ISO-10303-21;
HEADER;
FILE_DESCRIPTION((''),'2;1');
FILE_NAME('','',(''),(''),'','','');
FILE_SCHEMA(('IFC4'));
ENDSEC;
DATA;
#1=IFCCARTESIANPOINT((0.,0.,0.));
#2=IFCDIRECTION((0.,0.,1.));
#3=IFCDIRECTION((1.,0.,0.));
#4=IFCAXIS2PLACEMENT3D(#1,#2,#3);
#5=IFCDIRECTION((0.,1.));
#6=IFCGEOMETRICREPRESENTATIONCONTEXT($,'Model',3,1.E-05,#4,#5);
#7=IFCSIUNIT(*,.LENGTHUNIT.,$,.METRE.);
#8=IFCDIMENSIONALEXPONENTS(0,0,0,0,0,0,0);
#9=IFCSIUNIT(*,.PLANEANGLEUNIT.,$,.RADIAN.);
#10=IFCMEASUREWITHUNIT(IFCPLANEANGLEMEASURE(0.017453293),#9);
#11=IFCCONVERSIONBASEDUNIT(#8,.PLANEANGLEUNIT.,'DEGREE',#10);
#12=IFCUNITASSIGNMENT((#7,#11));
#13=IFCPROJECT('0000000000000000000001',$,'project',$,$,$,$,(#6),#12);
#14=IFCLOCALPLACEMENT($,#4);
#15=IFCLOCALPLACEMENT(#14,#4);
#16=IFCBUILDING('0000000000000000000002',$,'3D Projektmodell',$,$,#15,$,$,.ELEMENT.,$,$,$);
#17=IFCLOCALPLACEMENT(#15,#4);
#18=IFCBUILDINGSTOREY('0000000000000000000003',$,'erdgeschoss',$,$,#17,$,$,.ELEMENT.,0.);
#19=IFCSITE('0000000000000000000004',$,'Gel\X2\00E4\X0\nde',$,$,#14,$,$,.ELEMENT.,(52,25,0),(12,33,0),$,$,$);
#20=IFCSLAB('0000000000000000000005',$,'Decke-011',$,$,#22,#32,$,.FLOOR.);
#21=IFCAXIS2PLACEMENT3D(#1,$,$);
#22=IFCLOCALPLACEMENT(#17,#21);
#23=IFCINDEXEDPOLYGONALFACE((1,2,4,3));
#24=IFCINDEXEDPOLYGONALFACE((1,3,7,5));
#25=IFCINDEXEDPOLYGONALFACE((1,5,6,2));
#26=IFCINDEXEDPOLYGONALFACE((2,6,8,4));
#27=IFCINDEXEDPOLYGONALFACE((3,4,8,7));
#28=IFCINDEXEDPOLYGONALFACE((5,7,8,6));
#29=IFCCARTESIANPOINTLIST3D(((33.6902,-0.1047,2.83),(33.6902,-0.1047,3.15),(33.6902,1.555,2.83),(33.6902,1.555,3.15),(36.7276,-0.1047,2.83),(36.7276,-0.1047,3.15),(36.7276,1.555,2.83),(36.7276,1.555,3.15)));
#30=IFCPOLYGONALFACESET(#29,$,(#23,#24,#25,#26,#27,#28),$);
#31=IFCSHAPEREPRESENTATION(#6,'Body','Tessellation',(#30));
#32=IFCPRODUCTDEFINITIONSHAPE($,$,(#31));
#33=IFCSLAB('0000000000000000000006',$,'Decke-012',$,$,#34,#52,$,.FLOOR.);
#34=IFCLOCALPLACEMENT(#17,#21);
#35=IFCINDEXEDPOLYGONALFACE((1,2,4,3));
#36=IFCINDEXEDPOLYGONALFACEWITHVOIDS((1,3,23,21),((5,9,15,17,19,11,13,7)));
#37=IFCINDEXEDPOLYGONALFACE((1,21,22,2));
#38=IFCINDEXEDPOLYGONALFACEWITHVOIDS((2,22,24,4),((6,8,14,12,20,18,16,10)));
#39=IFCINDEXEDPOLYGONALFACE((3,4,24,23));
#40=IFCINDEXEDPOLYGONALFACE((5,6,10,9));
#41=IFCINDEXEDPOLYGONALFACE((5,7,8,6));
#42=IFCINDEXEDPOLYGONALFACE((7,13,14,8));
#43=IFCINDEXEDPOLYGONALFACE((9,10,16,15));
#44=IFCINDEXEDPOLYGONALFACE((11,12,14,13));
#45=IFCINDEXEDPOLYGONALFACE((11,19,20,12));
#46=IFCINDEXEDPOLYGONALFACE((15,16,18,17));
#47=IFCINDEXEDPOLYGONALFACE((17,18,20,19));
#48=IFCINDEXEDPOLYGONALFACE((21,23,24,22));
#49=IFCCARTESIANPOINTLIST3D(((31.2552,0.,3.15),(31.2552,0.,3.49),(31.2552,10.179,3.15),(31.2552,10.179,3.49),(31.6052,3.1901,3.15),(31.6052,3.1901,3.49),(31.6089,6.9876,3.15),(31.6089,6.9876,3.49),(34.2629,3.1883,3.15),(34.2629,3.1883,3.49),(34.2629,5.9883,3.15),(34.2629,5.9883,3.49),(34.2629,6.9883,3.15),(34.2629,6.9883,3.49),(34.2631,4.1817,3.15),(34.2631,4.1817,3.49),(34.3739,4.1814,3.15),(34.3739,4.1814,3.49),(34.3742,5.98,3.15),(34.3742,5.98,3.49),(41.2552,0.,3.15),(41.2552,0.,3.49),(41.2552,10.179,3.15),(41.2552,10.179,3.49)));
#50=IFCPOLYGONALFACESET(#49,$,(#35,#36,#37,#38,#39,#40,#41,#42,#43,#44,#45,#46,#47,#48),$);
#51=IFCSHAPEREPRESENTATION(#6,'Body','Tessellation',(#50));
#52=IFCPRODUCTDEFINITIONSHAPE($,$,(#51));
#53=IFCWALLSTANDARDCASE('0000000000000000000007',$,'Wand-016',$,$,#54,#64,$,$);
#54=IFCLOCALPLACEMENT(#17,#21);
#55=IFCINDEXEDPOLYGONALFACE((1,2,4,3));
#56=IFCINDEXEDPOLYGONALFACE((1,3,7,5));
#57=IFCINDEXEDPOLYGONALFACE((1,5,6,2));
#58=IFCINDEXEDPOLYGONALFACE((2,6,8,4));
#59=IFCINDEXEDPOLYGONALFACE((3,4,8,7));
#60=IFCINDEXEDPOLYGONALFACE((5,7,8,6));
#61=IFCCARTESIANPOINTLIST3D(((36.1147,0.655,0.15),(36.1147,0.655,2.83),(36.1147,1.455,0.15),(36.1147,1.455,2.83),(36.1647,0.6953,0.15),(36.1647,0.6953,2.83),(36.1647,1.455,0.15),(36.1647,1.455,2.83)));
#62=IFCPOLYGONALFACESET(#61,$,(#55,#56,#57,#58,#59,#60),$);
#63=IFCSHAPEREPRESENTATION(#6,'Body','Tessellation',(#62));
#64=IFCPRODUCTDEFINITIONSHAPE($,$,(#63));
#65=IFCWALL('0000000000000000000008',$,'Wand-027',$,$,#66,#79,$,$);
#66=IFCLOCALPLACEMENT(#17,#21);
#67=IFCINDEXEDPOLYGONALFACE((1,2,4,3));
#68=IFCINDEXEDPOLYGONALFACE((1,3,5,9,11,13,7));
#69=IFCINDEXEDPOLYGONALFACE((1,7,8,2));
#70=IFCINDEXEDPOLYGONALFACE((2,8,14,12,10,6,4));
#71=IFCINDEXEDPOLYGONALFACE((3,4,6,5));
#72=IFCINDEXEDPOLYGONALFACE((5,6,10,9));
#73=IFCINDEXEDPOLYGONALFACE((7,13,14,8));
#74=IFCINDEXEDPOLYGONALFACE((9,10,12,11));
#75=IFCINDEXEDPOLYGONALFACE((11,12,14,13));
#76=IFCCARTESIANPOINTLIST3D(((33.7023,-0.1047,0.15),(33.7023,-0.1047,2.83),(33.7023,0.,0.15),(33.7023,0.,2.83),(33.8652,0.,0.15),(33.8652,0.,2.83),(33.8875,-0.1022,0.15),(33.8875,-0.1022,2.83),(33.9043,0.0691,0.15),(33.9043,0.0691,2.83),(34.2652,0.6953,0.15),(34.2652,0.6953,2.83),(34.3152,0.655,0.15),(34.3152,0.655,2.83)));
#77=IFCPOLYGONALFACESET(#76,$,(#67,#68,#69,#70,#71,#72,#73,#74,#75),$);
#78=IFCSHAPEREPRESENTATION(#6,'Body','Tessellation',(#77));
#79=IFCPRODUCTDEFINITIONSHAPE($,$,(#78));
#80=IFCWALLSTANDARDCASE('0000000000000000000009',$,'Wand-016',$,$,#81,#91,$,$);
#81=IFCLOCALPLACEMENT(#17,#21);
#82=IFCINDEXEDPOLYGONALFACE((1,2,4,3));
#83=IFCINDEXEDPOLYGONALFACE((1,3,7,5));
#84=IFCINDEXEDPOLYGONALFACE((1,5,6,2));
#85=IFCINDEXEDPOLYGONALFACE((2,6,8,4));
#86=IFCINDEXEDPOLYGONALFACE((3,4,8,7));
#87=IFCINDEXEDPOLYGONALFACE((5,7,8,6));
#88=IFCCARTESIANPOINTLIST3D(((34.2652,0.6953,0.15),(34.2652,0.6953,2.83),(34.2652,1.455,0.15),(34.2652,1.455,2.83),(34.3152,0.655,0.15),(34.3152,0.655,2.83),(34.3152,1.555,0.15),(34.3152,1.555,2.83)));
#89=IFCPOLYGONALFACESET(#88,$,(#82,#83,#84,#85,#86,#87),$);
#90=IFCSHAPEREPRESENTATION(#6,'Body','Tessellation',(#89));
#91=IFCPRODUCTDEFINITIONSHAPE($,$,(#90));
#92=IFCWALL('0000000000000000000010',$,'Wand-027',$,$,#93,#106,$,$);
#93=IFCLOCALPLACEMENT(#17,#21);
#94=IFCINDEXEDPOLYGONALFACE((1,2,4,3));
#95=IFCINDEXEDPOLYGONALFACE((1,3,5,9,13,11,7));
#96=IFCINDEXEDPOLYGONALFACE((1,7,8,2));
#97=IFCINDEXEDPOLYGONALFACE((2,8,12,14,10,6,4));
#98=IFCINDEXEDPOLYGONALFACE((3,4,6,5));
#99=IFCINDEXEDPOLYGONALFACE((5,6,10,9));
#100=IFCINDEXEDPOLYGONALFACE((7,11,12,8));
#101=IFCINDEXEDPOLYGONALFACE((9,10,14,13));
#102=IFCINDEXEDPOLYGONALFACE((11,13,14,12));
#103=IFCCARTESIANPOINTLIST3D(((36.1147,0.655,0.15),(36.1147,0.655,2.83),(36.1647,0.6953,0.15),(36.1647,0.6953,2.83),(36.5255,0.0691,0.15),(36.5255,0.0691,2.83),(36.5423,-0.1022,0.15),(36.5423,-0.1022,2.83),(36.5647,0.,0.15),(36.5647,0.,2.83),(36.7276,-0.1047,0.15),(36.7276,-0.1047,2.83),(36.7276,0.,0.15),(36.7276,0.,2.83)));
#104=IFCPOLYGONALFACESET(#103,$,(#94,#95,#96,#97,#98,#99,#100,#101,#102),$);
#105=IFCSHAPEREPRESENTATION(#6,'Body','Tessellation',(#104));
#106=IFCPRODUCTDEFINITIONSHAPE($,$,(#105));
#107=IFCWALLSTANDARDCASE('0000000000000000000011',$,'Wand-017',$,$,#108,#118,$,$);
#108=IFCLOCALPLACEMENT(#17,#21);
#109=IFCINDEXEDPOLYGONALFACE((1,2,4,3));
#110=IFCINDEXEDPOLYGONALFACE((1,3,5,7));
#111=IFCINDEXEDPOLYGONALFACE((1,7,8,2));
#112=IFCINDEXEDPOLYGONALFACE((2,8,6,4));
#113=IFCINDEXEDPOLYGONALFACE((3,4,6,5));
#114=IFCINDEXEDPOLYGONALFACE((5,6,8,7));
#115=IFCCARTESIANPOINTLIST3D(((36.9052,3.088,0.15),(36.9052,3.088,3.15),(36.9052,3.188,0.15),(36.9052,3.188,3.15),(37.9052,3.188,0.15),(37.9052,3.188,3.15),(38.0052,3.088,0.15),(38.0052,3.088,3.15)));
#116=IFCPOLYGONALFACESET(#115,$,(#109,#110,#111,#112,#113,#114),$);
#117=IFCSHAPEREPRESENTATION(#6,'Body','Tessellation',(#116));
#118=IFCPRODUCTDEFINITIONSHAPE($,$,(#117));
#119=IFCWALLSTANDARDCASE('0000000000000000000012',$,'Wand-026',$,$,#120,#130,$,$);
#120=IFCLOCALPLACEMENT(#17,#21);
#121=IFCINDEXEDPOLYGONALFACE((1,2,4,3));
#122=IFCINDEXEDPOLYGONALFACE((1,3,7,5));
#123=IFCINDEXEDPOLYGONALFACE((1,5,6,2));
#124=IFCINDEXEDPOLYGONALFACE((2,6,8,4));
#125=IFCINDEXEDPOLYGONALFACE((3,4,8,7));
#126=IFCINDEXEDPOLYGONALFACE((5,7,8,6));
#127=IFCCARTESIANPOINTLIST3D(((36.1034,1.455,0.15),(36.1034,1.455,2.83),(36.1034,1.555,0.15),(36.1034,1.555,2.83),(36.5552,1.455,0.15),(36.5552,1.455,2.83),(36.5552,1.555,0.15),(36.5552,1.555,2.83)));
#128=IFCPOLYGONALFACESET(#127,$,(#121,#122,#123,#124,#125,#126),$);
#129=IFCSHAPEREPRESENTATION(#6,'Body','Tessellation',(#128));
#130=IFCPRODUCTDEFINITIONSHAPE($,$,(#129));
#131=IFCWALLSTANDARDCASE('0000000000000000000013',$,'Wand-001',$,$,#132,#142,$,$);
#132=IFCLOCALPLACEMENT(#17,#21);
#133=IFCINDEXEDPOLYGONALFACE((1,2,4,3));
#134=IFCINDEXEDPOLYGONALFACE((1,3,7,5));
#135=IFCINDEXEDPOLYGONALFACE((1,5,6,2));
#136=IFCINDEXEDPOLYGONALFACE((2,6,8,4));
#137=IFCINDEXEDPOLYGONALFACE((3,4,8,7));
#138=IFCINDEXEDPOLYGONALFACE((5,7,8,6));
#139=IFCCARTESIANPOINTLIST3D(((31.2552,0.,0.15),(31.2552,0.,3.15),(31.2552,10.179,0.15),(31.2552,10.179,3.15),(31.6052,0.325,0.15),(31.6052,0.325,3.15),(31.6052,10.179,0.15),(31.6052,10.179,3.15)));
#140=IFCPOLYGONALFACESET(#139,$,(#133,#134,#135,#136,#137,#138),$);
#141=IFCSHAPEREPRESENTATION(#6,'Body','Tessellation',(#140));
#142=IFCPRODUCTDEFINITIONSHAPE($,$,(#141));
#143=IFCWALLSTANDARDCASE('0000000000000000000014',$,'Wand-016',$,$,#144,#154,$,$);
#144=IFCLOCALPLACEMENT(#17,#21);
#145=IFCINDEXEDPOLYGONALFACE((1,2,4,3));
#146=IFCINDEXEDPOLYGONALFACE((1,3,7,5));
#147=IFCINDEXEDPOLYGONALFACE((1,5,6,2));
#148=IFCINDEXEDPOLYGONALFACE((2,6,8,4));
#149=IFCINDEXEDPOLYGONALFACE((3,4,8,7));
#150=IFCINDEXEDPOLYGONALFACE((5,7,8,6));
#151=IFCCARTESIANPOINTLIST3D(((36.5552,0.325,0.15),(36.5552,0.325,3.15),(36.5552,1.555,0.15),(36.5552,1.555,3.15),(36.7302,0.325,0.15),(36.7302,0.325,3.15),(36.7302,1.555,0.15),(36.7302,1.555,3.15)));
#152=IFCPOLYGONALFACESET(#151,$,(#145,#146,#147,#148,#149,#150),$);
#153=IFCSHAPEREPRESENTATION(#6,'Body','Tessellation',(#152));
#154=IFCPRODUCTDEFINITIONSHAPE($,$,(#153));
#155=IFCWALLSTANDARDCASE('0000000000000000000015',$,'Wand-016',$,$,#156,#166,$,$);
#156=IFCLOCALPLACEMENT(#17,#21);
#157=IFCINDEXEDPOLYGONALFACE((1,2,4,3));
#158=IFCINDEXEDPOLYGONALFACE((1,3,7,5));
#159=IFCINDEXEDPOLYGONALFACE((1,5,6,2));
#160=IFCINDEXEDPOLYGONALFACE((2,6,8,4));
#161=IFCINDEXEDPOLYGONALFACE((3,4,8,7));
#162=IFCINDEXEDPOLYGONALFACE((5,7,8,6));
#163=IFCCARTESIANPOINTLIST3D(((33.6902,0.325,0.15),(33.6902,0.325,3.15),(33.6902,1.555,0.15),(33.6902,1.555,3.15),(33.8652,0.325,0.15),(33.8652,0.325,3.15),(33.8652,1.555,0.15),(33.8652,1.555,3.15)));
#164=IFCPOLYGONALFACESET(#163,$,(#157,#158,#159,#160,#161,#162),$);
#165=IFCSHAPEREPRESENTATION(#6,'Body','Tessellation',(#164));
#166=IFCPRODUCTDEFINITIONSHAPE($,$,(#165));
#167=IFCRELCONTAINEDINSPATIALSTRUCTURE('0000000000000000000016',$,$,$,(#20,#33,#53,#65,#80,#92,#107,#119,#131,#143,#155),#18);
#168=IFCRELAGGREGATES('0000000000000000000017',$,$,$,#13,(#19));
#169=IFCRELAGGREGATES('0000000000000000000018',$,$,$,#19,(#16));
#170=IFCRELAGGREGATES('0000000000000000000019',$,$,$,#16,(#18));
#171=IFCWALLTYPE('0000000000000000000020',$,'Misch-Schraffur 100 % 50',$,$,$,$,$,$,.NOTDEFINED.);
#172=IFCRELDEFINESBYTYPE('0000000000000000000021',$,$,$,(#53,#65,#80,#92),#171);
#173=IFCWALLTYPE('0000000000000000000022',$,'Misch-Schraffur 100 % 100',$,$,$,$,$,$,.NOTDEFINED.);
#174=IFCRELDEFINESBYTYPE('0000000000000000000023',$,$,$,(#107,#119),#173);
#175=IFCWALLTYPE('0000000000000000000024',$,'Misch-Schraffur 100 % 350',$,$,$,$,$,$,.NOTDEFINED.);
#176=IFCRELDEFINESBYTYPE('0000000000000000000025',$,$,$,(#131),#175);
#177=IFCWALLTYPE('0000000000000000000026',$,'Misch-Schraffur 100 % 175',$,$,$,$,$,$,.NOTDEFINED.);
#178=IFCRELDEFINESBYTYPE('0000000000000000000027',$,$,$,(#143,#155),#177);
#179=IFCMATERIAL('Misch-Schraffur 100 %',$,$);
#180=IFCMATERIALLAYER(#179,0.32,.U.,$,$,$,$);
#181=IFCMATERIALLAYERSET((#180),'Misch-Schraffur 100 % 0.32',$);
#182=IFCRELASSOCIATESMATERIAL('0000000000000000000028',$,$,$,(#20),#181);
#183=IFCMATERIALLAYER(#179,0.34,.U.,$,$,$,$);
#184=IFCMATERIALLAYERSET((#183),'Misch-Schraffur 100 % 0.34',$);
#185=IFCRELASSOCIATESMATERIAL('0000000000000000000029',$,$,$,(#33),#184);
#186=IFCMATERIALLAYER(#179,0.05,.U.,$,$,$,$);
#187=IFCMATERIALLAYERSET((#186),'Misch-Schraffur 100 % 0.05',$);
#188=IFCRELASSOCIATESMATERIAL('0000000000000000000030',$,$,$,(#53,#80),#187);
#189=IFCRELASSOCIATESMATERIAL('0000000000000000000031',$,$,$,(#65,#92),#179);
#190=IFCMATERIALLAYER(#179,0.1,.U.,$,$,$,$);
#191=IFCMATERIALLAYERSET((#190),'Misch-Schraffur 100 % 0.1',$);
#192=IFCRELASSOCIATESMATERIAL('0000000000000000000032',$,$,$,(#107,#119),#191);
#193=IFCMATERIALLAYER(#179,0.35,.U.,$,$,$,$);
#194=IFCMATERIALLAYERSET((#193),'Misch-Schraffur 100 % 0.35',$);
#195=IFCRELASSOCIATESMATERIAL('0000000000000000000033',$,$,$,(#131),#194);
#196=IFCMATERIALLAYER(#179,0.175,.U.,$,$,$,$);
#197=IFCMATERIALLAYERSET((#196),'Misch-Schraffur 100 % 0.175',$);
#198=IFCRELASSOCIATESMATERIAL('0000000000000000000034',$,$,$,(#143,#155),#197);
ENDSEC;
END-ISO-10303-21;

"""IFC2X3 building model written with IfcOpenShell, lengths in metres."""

from ifc_helpers import new_model, entity, si_unit, converted_unit, direction, frame, origin_with_axes, place, context, project, spatial, polyline, outline, extrude, material, layer, layer_set, layer_usage, type_object, element, save


model = new_model("IFC2X3")

# Units and contexts
model_context = context("Model", 3, precision=1e-05, world=origin_with_axes(), true_north=direction((0.0, 1.0)))
ifc_project = project(units=[si_unit("LENGTHUNIT", "METRE"), converted_unit("PLANEANGLEUNIT", "DEGREE", entity("IfcPlaneAngleMeasure", 0.017453293), si_unit("PLANEANGLEUNIT", "RADIAN"), dimensions=[0, 0, 0, 0, 0, 0, 0])], contexts=[model_context])

# Site, building, storey
site_placement = place(None, origin_with_axes())
site = spatial("IfcSite", under=ifc_project, at=site_placement, Name="Gelände", CompositionType="ELEMENT", RefLatitude=(52, 25, 0), RefLongitude=(12, 33, 0))
building_placement = place(site_placement, origin_with_axes())
building = spatial("IfcBuilding", under=site, at=building_placement, Name="3D Projektmodell", CompositionType="ELEMENT")
storey_placement = place(building_placement, origin_with_axes())
storey = spatial("IfcBuildingStorey", under=building, at=storey_placement, Name="erdgeschoss", CompositionType="ELEMENT", Elevation=0.0)

# Slabs
ifc_material = material(Name="Misch-Schraffur 100 %")
ifc_layer_1 = layer(ifc_material, 0.32, ventilated="UNKNOWN")
ifc_layer_set_1 = layer_set([ifc_layer_1], Name="Misch-Schraffur 100 % 0.32")
ifc_layer_usage_1 = layer_usage(ifc_layer_set_1, "AXIS3", "NEGATIVE", 0.32)
slab_1_placement = place(storey_placement, frame((33.6902, 1.555, 2.83), z_axis=(0.0, 0.0, 1.0), x_axis=(1.0, 0.0, 0.0)))
element("IfcSlab", 1, at=slab_1_placement, inside=storey, material=ifc_layer_usage_1, Name="Decke-011", PredefinedType="FLOOR", context=model_context, shape_type="SweptSolid", body=[
    extrude(outline(polyline([(0.0, 0.0), (0.0, -1.6597), (3.0374, -1.6597), (3.0374, 0.0), (0.0, 0.0)])), origin_with_axes(), (0.0, 0.0, 1.0), 0.32),
])
ifc_layer_2 = layer(ifc_material, 0.34, ventilated="UNKNOWN")
ifc_layer_set_2 = layer_set([ifc_layer_2], Name="Misch-Schraffur 100 % 0.34")
ifc_layer_usage_2 = layer_usage(ifc_layer_set_2, "AXIS3", "NEGATIVE", 0.34)
slab_2_placement = place(storey_placement, frame((31.2552, 0.0, 3.15), z_axis=(0.0, 0.0, 1.0), x_axis=(1.0, 0.0, 0.0)))
element("IfcSlab", 2, at=slab_2_placement, inside=storey, material=ifc_layer_usage_2, Name="Decke-012", PredefinedType="FLOOR", context=model_context, shape_type="SweptSolid", body=[
    extrude(outline(polyline([(0.0, 0.0), (10.0, 0.0), (10.0, 10.179), (0.0, 10.179), (0.0, 0.0)]), holes=[polyline([(0.3537, 6.9876), (3.0077, 6.9883), (3.0077, 5.9883), (3.119, 5.98), (3.1187, 4.1814), (3.0079, 4.1817), (3.0077, 3.1883), (0.35, 3.1901), (0.3537, 6.9876)])]), origin_with_axes(), (0.0, 0.0, 1.0), 0.34),
])

# Walls
ifc_layer_3 = layer(ifc_material, 0.05, ventilated="UNKNOWN")
ifc_layer_set_3 = layer_set([ifc_layer_3], Name="Misch-Schraffur 100 % 0.05")
ifc_layer_usage_3 = layer_usage(ifc_layer_set_3, "AXIS2", "NEGATIVE", 0.0)
wall_type_1 = type_object("IfcWallType", Name="Misch-Schraffur 100 % 50", PredefinedType="NOTDEFINED")
wall_1_placement = place(storey_placement, frame((36.1147, 0.655, 0.15), z_axis=(0.0, 0.0, 1.0), x_axis=(0.0, 1.0, 0.0)))
element("IfcWallStandardCase", 3, at=wall_1_placement, inside=storey, type_object=wall_type_1, material=ifc_layer_usage_3, Name="Wand-016", context=model_context, shape_type="SweptSolid", body=[
    extrude(outline(polyline([(0.0403, -0.05), (0.8, -0.05), (0.8, 0.0), (0.0, 0.0), (0.0403, -0.05)])), origin_with_axes(), (0.0, 0.0, 1.0), 2.68),
])
wall_2_placement = place(storey_placement, frame((34.2652, 0.6953, 0.15), z_axis=(0.0, 0.0, 1.0), x_axis=(-0.499276, -0.866443, 0.0)))
element("IfcWall", 4, at=wall_2_placement, inside=storey, type_object=wall_type_1, material=ifc_material, Name="Wand-027", context=model_context, shape_type="SweptSolid", body=[
    extrude(outline(polyline([(0.0, 0.0), (0.7228, 0.0), (0.8021, 0.0006), (0.8835, -0.1406), (0.9742, -0.0883), (0.8795, 0.0709), (0.0099, 0.0634), (0.0, 0.0)])), origin_with_axes(), (0.0, 0.0, 1.0), 2.68),
])
ifc_layer_usage_4 = layer_usage(ifc_layer_set_3, "AXIS2", "POSITIVE", 0.0)
wall_3_placement = place(storey_placement, frame((34.3152, 0.655, 0.15), z_axis=(0.0, 0.0, 1.0), x_axis=(0.0, 1.0, 0.0)))
element("IfcWallStandardCase", 5, at=wall_3_placement, inside=storey, type_object=wall_type_1, material=ifc_layer_usage_4, Name="Wand-016", context=model_context, shape_type="SweptSolid", body=[
    extrude(outline(polyline([(0.0, 0.0), (0.9, 0.0), (0.8, 0.05), (0.0403, 0.05), (0.0, 0.0)])), origin_with_axes(), (0.0, 0.0, 1.0), 2.68),
])
wall_4_placement = place(storey_placement, frame((36.5255, 0.0691, 0.15), z_axis=(0.0, 0.0, 1.0), x_axis=(-0.499276, 0.866443, 0.0)))
element("IfcWall", 6, at=wall_4_placement, inside=storey, type_object=wall_type_1, material=ifc_material, Name="Wand-027", context=model_context, shape_type="SweptSolid", body=[
    extrude(outline(polyline([(0.7128, 0.0634), (-0.1567, 0.0709), (-0.2514, -0.0883), (-0.1607, -0.1406), (-0.0794, 0.0006), (0.0, 0.0), (0.7228, 0.0), (0.7128, 0.0634)])), origin_with_axes(), (0.0, 0.0, 1.0), 2.68),
])

# Walls
ifc_layer_4 = layer(ifc_material, 0.1, ventilated="UNKNOWN")
ifc_layer_set_4 = layer_set([ifc_layer_4], Name="Misch-Schraffur 100 % 0.1")
ifc_layer_usage_5 = layer_usage(ifc_layer_set_4, "AXIS2", "POSITIVE", 0.0)
wall_type_2 = type_object("IfcWallType", Name="Misch-Schraffur 100 % 100", PredefinedType="NOTDEFINED")
wall_5_placement = place(storey_placement, frame((36.9052, 3.088, 0.15), z_axis=(0.0, 0.0, 1.0), x_axis=(1.0, 0.0, 0.0)))
element("IfcWallStandardCase", 7, at=wall_5_placement, inside=storey, type_object=wall_type_2, material=ifc_layer_usage_5, Name="Wand-017", context=model_context, shape_type="SweptSolid", body=[
    extrude(outline(polyline([(0.0, 0.0), (1.1, 0.0), (1.0, 0.1), (0.0, 0.1), (0.0, 0.0)])), origin_with_axes(), (0.0, 0.0, 1.0), 3.0),
])
ifc_layer_usage_6 = layer_usage(ifc_layer_set_4, "AXIS2", "POSITIVE", 0.0)
wall_6_placement = place(storey_placement, frame((36.1034, 1.455, 0.15), z_axis=(0.0, 0.0, 1.0), x_axis=(1.0, 0.0, 0.0)))
element("IfcWallStandardCase", 8, at=wall_6_placement, inside=storey, type_object=wall_type_2, material=ifc_layer_usage_6, Name="Wand-026", context=model_context, shape_type="SweptSolid", body=[
    extrude(outline(polyline([(0.0, 0.0), (0.4518, 0.0), (0.4518, 0.1), (0.0, 0.1), (0.0, 0.0)])), origin_with_axes(), (0.0, 0.0, 1.0), 2.68),
])

# Walls
ifc_layer_5 = layer(ifc_material, 0.35, ventilated="UNKNOWN")
ifc_layer_set_5 = layer_set([ifc_layer_5], Name="Misch-Schraffur 100 % 0.35")
ifc_layer_usage_7 = layer_usage(ifc_layer_set_5, "AXIS2", "NEGATIVE", 0.0)
wall_type_3 = type_object("IfcWallType", Name="Misch-Schraffur 100 % 350", PredefinedType="NOTDEFINED")
wall_7_placement = place(storey_placement, frame((31.2552, 0.0, 0.15), z_axis=(0.0, 0.0, 1.0), x_axis=(0.0, 1.0, 0.0)))
element("IfcWallStandardCase", 9, at=wall_7_placement, inside=storey, type_object=wall_type_3, material=ifc_layer_usage_7, Name="Wand-001", context=model_context, shape_type="SweptSolid", body=[
    extrude(outline(polyline([(0.325, -0.35), (10.179, -0.35), (10.179, 0.0), (0.0, 0.0), (0.325, -0.35)])), origin_with_axes(), (0.0, 0.0, 1.0), 3.0),
])
ifc_layer_6 = layer(ifc_material, 0.175, ventilated="UNKNOWN")
ifc_layer_set_6 = layer_set([ifc_layer_6], Name="Misch-Schraffur 100 % 0.175")
ifc_layer_usage_8 = layer_usage(ifc_layer_set_6, "AXIS2", "NEGATIVE", 0.0)
wall_type_4 = type_object("IfcWallType", Name="Misch-Schraffur 100 % 175", PredefinedType="NOTDEFINED")
wall_8_placement = place(storey_placement, frame((36.5552, 0.325, 0.15), z_axis=(0.0, 0.0, 1.0), x_axis=(0.0, 1.0, 0.0)))
element("IfcWallStandardCase", 10, at=wall_8_placement, inside=storey, type_object=wall_type_4, material=ifc_layer_usage_8, Name="Wand-016", context=model_context, shape_type="SweptSolid", body=[
    extrude(outline(polyline([(0.0, -0.175), (1.23, -0.175), (1.23, 0.0), (0.0, 0.0), (0.0, -0.175)])), origin_with_axes(), (0.0, 0.0, 1.0), 3.0),
])
ifc_layer_usage_9 = layer_usage(ifc_layer_set_6, "AXIS2", "POSITIVE", 0.0)
wall_9_placement = place(storey_placement, frame((33.8652, 0.325, 0.15), z_axis=(0.0, 0.0, 1.0), x_axis=(0.0, 1.0, 0.0)))
element("IfcWallStandardCase", 11, at=wall_9_placement, inside=storey, type_object=wall_type_4, material=ifc_layer_usage_9, Name="Wand-016", context=model_context, shape_type="SweptSolid", body=[
    extrude(outline(polyline([(0.0, 0.0), (1.23, 0.0), (1.23, 0.175), (0.0, 0.175), (0.0, 0.0)])), origin_with_axes(), (0.0, 0.0, 1.0), 3.0),
])

save(model, "model.ifc")
